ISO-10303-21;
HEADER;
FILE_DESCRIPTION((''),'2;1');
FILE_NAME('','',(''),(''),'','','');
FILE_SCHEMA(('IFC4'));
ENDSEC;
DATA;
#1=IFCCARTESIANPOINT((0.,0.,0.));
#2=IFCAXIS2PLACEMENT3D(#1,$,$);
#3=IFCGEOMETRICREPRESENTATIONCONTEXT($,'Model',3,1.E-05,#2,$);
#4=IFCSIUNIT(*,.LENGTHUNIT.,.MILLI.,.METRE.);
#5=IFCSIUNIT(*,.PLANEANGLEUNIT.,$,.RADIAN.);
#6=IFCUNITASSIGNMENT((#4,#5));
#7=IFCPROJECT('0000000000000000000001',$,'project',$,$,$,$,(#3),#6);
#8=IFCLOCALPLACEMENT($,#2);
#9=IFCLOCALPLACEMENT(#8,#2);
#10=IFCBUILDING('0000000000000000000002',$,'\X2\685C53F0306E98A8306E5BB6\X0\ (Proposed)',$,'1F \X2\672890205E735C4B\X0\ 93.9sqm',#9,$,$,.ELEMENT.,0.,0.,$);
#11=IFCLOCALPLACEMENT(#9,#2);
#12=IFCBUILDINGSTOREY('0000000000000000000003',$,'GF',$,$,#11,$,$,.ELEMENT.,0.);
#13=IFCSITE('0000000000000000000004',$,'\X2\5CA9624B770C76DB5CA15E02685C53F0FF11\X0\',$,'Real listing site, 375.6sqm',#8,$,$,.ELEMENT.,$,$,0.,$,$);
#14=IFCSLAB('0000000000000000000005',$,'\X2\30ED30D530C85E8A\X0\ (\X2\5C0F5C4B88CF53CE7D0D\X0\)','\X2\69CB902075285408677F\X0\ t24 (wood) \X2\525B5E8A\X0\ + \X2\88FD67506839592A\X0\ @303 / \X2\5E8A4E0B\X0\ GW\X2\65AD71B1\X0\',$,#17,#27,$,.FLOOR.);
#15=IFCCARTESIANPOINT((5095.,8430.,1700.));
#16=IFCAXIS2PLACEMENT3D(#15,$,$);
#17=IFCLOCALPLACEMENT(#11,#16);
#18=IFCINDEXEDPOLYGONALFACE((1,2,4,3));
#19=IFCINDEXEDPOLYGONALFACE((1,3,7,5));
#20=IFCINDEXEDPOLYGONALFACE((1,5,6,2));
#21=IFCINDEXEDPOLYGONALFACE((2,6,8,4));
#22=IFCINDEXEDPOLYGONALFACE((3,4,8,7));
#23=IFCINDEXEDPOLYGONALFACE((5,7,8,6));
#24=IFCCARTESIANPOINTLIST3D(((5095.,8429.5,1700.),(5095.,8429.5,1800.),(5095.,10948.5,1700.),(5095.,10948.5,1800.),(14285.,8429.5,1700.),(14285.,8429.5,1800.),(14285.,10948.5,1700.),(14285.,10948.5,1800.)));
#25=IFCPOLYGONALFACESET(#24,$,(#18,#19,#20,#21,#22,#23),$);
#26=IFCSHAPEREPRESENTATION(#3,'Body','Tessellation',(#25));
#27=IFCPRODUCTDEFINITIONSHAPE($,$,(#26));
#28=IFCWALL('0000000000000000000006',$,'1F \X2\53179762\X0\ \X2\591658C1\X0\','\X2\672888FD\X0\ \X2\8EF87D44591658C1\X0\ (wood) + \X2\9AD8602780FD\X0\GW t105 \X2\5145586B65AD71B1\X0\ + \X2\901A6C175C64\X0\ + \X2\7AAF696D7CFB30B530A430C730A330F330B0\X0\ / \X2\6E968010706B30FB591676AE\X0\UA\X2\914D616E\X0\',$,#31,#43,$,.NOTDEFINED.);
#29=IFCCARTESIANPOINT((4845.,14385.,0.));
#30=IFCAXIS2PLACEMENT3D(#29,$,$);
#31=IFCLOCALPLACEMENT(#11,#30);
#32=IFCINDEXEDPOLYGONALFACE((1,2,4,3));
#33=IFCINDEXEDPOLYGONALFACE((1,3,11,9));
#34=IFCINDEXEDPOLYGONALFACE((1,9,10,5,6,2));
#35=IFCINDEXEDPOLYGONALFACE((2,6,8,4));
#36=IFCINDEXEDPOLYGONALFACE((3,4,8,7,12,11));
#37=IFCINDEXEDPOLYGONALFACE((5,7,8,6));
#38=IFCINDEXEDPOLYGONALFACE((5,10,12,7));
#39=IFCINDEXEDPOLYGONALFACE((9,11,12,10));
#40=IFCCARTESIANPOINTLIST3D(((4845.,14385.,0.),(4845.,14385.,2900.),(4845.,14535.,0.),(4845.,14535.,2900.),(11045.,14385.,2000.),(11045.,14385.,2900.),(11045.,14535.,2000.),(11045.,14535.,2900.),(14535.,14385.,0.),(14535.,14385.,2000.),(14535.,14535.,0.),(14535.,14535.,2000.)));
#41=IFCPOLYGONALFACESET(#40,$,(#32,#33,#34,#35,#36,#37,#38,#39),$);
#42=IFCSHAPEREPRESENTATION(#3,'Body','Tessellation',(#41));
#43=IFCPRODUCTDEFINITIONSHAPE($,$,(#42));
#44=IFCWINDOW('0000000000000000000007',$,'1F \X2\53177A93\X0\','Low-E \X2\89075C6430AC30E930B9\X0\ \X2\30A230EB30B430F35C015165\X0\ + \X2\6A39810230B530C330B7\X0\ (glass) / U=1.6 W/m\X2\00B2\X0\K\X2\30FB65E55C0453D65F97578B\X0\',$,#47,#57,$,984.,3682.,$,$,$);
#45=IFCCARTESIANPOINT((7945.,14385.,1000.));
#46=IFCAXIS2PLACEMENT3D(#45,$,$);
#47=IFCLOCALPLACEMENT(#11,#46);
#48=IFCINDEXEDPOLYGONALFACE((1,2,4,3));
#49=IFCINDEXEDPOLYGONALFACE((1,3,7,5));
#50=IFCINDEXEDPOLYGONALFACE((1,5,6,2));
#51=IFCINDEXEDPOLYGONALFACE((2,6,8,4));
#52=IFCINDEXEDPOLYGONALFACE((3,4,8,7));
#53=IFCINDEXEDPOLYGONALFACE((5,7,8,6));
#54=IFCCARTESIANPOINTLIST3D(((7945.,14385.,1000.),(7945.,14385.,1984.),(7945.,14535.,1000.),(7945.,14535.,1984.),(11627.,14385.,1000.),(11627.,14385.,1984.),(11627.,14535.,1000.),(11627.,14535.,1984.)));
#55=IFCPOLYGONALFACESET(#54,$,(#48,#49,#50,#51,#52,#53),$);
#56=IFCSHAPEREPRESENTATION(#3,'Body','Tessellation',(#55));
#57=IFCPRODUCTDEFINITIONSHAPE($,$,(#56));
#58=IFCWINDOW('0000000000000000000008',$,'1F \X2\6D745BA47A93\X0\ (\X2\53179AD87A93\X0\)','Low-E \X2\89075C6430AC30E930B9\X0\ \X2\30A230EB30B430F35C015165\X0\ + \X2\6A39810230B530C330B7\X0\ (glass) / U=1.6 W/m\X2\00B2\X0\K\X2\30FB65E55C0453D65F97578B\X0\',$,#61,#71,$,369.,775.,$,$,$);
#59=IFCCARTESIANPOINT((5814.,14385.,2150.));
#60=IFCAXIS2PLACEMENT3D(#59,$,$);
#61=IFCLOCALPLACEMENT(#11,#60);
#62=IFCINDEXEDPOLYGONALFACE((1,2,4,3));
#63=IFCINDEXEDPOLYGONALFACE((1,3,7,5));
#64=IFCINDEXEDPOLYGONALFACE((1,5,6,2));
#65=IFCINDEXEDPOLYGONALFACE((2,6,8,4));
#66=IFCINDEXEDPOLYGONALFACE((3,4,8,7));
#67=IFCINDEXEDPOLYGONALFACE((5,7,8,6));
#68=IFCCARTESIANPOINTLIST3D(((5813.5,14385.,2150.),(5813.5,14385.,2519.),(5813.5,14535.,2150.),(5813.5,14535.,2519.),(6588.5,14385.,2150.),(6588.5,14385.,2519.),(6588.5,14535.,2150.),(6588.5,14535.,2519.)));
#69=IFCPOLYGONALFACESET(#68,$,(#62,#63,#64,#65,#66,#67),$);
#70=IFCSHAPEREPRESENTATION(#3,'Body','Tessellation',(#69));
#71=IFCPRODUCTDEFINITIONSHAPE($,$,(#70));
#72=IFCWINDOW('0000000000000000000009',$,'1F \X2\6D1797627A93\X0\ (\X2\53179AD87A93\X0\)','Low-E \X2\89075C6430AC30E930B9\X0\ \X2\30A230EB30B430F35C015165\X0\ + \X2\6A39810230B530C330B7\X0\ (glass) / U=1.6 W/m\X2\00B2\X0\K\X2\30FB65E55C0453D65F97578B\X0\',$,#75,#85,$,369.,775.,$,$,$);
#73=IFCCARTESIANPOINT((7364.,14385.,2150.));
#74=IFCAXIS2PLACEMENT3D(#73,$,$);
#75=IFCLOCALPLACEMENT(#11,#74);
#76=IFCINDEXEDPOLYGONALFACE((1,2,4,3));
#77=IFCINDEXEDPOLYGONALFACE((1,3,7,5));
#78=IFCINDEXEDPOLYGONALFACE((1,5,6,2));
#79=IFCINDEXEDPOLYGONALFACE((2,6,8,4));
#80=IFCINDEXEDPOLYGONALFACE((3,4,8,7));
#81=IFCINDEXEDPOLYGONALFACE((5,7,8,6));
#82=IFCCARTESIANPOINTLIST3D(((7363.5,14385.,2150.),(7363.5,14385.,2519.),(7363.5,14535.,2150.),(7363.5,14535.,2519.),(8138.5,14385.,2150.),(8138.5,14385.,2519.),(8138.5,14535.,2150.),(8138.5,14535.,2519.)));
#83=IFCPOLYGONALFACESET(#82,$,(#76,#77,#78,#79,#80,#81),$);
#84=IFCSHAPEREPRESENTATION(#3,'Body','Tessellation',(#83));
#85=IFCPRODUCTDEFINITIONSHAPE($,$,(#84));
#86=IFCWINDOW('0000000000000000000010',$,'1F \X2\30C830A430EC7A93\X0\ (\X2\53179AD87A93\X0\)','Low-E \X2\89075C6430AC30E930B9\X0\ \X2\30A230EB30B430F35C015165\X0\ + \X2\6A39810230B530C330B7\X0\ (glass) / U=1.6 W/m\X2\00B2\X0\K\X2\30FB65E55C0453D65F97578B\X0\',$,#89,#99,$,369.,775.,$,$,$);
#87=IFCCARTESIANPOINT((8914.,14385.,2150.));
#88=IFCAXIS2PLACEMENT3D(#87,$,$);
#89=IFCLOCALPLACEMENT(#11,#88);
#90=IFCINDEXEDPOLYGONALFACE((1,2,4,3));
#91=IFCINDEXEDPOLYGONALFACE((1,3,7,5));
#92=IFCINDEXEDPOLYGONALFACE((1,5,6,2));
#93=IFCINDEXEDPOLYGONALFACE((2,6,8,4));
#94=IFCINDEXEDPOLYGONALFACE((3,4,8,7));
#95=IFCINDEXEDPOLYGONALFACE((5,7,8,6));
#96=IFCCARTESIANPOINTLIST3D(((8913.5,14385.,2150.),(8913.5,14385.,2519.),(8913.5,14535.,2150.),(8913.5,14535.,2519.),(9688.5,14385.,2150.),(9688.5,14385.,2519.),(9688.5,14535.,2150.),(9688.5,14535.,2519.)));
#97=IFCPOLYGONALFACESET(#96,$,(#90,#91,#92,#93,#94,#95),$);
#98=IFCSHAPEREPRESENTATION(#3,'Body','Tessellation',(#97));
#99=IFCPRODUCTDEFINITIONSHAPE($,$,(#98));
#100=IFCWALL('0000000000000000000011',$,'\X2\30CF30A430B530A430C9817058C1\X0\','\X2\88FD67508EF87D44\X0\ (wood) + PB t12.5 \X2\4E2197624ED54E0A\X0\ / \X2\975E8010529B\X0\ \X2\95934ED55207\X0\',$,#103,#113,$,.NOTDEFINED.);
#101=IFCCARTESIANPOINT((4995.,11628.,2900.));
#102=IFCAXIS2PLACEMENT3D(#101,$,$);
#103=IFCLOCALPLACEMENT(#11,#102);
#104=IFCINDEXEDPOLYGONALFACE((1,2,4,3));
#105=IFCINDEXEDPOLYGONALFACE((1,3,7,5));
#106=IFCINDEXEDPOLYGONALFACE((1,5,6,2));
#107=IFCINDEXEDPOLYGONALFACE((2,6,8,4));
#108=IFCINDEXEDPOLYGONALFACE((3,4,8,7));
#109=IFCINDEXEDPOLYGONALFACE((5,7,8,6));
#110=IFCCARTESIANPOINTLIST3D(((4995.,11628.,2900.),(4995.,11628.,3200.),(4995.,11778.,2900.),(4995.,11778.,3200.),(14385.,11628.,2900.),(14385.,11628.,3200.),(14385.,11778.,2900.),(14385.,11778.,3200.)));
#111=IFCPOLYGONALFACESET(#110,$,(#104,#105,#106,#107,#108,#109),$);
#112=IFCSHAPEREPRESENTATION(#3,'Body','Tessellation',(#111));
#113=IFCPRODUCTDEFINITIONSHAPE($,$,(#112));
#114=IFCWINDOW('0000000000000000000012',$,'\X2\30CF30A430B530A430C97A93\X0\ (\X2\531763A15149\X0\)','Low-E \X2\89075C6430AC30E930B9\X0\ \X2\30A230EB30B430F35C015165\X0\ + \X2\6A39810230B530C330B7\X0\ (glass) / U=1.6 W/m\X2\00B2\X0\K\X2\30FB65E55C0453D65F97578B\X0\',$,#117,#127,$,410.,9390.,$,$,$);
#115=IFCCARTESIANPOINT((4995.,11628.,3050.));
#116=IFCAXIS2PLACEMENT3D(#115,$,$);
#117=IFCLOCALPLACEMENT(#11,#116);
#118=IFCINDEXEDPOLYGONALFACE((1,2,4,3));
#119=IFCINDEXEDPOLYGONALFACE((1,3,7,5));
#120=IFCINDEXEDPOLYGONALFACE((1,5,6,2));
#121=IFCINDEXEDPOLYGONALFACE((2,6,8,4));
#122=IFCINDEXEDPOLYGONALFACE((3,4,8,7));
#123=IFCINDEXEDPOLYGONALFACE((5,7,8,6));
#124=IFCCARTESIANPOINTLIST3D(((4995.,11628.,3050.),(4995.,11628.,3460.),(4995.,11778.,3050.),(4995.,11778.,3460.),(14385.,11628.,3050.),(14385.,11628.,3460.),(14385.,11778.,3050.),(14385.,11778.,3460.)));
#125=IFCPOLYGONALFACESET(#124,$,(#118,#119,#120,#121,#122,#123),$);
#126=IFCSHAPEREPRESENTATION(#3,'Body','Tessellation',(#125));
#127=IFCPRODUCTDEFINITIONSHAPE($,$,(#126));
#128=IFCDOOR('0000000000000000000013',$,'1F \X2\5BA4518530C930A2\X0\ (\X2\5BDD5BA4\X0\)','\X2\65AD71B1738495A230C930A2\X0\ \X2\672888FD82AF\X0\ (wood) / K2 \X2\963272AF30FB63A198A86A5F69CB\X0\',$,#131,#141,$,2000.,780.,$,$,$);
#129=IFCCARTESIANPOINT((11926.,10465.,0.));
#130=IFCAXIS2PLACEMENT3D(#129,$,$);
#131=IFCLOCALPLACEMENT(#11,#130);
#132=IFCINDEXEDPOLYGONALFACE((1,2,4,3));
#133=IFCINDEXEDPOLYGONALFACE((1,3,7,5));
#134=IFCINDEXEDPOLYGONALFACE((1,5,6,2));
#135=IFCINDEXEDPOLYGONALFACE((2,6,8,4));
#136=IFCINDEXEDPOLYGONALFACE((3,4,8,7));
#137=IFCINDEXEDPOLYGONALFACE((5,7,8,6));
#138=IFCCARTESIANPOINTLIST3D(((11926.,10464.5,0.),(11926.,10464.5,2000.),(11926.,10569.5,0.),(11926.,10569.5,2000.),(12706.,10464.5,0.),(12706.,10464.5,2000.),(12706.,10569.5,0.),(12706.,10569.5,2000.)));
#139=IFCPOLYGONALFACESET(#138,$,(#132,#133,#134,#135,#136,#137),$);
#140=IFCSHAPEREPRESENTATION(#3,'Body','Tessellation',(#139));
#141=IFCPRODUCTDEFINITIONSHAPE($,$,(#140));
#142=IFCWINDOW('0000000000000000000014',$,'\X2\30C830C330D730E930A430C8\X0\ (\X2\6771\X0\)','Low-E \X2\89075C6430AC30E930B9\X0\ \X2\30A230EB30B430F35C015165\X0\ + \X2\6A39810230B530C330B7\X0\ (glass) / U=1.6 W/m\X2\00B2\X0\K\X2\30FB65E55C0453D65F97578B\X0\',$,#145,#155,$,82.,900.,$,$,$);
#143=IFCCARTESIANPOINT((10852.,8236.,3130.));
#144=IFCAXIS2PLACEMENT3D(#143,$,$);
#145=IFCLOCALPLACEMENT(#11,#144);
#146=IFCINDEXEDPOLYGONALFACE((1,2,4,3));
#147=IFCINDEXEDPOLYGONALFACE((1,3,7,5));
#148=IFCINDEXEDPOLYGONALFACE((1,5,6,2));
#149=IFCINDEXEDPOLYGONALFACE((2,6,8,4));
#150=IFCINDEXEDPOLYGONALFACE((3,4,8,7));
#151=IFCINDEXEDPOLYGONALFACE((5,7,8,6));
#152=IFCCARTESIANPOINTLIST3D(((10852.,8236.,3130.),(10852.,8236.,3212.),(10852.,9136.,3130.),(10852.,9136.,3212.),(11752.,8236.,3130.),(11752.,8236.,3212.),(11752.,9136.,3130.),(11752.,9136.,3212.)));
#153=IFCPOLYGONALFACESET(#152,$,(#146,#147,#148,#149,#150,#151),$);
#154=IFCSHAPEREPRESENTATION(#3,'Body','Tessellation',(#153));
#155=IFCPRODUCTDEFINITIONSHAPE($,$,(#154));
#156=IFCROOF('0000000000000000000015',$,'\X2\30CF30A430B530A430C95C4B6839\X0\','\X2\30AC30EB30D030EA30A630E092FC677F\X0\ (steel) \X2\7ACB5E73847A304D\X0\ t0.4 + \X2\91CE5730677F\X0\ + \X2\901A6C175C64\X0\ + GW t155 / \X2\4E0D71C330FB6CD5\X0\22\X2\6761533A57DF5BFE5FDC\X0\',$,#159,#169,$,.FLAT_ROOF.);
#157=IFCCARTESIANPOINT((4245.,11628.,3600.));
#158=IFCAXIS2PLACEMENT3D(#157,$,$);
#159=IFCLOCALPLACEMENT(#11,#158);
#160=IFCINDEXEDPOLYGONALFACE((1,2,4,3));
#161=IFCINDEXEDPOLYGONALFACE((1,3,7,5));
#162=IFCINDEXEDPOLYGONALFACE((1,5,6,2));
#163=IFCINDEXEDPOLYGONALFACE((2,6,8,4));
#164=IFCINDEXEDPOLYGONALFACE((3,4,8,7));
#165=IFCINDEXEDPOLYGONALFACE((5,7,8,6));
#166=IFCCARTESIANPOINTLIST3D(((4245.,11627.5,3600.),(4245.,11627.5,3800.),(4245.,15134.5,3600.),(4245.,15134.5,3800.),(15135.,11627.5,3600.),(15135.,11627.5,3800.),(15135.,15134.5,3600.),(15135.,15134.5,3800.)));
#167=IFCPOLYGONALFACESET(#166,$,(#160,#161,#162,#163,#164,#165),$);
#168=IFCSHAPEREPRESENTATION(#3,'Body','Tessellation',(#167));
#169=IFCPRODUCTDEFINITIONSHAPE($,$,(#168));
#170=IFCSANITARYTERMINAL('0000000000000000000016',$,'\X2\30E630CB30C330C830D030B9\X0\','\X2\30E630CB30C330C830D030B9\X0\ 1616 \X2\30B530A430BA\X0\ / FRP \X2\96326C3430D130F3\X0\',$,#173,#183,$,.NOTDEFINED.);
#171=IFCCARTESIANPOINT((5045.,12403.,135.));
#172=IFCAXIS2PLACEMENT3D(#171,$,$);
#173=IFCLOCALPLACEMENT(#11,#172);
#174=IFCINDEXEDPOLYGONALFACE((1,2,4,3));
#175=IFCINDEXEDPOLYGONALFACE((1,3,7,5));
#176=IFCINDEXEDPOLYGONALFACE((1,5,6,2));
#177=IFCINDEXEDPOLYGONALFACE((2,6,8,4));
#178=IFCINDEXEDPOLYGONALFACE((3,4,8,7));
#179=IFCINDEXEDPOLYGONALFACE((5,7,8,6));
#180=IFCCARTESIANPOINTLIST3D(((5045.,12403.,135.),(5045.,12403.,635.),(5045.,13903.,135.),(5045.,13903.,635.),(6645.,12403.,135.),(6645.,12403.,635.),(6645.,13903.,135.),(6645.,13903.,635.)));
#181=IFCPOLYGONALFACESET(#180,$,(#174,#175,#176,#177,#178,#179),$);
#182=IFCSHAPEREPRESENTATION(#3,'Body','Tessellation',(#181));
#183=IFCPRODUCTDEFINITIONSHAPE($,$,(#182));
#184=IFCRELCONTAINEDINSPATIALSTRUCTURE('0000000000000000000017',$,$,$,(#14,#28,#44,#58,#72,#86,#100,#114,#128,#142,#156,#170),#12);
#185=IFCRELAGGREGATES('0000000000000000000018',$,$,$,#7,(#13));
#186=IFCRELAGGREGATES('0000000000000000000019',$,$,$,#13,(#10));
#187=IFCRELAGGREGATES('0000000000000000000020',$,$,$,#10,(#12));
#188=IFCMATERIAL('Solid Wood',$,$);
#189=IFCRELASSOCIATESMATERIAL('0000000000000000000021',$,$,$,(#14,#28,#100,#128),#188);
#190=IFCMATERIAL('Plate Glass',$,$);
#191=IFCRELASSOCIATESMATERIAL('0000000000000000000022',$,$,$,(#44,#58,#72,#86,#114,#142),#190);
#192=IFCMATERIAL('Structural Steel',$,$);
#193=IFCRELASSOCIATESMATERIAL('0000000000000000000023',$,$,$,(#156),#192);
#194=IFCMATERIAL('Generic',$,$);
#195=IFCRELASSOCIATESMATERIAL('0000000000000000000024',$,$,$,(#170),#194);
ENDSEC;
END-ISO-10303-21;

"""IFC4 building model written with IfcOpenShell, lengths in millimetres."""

from ifc_helpers import new_model, si_unit, frame, frame_2d, origin, place, context, project, spatial, rectangle, extrude, material, element, fill, save


model = new_model("IFC4")

# Units and contexts
model_context = context("Model", 3, precision=1e-05, world=origin())
ifc_project = project(units=[si_unit("LENGTHUNIT", "METRE", prefix="MILLI"), si_unit("PLANEANGLEUNIT", "RADIAN")], contexts=[model_context])

# Site, building, storey
site_placement = place(None, origin())
site = spatial("IfcSite", under=ifc_project, at=site_placement, Name="岩手県盛岡市桜台１", ObjectType="Real listing site, 375.6sqm", CompositionType="ELEMENT", RefElevation=0.0)
building_placement = place(site_placement, origin())
building = spatial("IfcBuilding", under=site, at=building_placement, Name="桜台の風の家 (Proposed)", ObjectType="1F 木造平屋 93.9sqm", CompositionType="ELEMENT", ElevationOfRefHeight=0.0, ElevationOfTerrain=0.0)
storey_placement = place(building_placement, origin())
storey = spatial("IfcBuildingStorey", under=building, at=storey_placement, Name="GF", CompositionType="ELEMENT", Elevation=0.0)

# Slab
ifc_material_1 = material(Name="Solid Wood")
slab_placement = place(storey_placement, frame((5095.0, 8430.0, 1700.0)))
element("IfcSlab", 1, at=slab_placement, inside=storey, material=ifc_material_1, Name="ロフト床 (小屋裏収納)", Description="構造用合板 t24 (wood) 剛床 + 製材根太 @303 / 床下 GW断熱", PredefinedType="FLOOR", context=model_context, shape_type="SweptSolid", body=[
    extrude(rectangle(XDim=9190.0, YDim=2519.0, at=frame_2d((4595.0, 1259.0))), frame((5095.0, 8430.0, 1700.0)), (0.0, 0.0, 1.0), 100.0),
])

# Wall, openings, windows
wall_1_placement = place(storey_placement, frame((4845.0, 14385.0, 0.0)))
wall_1 = element("IfcWall", 2, at=wall_1_placement, inside=storey, material=ifc_material_1, Name="1F 北面 外壁", Description="木製 軸組外壁 (wood) + 高性能GW t105 充填断熱 + 通気層 + 窯業系サイディング / 準耐火・外皮UA配慮", PredefinedType="NOTDEFINED", context=model_context, shape_type="SweptSolid", body=[
    extrude(rectangle(XDim=9690.0, YDim=150.0, at=frame_2d((4845.0, 75.0))), frame((4845.0, 14385.0, 0.0)), (0.0, 0.0, 1.0), 2900.0),
])
opening_1_placement = place(storey_placement, frame((7945.0, 14385.0, 1000.0)))
opening_1 = element("IfcOpeningElement", 3, at=opening_1_placement, cuts=wall_1, PredefinedType="NOTDEFINED", context=model_context, shape_type="SweptSolid", body=[
    extrude(rectangle(XDim=3682.0, YDim=150.0, at=frame_2d((1841.0, 75.0))), frame((7945.0, 14385.0, 1000.0)), (0.0, 0.0, 1.0), 984.0),
])
opening_2_placement = place(storey_placement, frame((5814.0, 14385.0, 2150.0)))
opening_2 = element("IfcOpeningElement", 4, at=opening_2_placement, cuts=wall_1, PredefinedType="NOTDEFINED", context=model_context, shape_type="SweptSolid", body=[
    extrude(rectangle(XDim=775.0, YDim=150.0, at=frame_2d((387.0, 75.0))), frame((5814.0, 14385.0, 2150.0)), (0.0, 0.0, 1.0), 369.0),
])
opening_3_placement = place(storey_placement, frame((7364.0, 14385.0, 2150.0)))
opening_3 = element("IfcOpeningElement", 5, at=opening_3_placement, cuts=wall_1, PredefinedType="NOTDEFINED", context=model_context, shape_type="SweptSolid", body=[
    extrude(rectangle(XDim=775.0, YDim=150.0, at=frame_2d((387.0, 75.0))), frame((7364.0, 14385.0, 2150.0)), (0.0, 0.0, 1.0), 369.0),
])
opening_4_placement = place(storey_placement, frame((8914.0, 14385.0, 2150.0)))
opening_4 = element("IfcOpeningElement", 6, at=opening_4_placement, cuts=wall_1, PredefinedType="NOTDEFINED", context=model_context, shape_type="SweptSolid", body=[
    extrude(rectangle(XDim=775.0, YDim=150.0, at=frame_2d((387.0, 75.0))), frame((8914.0, 14385.0, 2150.0)), (0.0, 0.0, 1.0), 369.0),
])
ifc_material_2 = material(Name="Plate Glass")
window_1_placement = place(storey_placement, frame((7945.0, 14385.0, 1000.0)))
window_1 = element("IfcWindow", 7, at=window_1_placement, inside=storey, material=ifc_material_2, Name="1F 北窓", Description="Low-E 複層ガラス アルゴン封入 + 樹脂サッシ (glass) / U=1.6 W/m²K・日射取得型", OverallHeight=984.0, OverallWidth=3682.0, context=model_context, shape_type="SweptSolid", body=[
    extrude(rectangle(XDim=3682.0, YDim=150.0, at=frame_2d((1841.0, 75.0))), frame((7945.0, 14385.0, 1000.0)), (0.0, 0.0, 1.0), 984.0),
])
fill(opening_1, window_1)
window_2_placement = place(storey_placement, frame((5814.0, 14385.0, 2150.0)))
window_2 = element("IfcWindow", 8, at=window_2_placement, inside=storey, material=ifc_material_2, Name="1F 浴室窓 (北高窓)", Description="Low-E 複層ガラス アルゴン封入 + 樹脂サッシ (glass) / U=1.6 W/m²K・日射取得型", OverallHeight=369.0, OverallWidth=775.0, context=model_context, shape_type="SweptSolid", body=[
    extrude(rectangle(XDim=775.0, YDim=150.0, at=frame_2d((387.0, 75.0))), frame((5814.0, 14385.0, 2150.0)), (0.0, 0.0, 1.0), 369.0),
])
fill(opening_2, window_2)
window_3_placement = place(storey_placement, frame((7364.0, 14385.0, 2150.0)))
window_3 = element("IfcWindow", 9, at=window_3_placement, inside=storey, material=ifc_material_2, Name="1F 洗面窓 (北高窓)", Description="Low-E 複層ガラス アルゴン封入 + 樹脂サッシ (glass) / U=1.6 W/m²K・日射取得型", OverallHeight=369.0, OverallWidth=775.0, context=model_context, shape_type="SweptSolid", body=[
    extrude(rectangle(XDim=775.0, YDim=150.0, at=frame_2d((387.0, 75.0))), frame((7364.0, 14385.0, 2150.0)), (0.0, 0.0, 1.0), 369.0),
])
fill(opening_3, window_3)
window_4_placement = place(storey_placement, frame((8914.0, 14385.0, 2150.0)))
window_4 = element("IfcWindow", 10, at=window_4_placement, inside=storey, material=ifc_material_2, Name="1F トイレ窓 (北高窓)", Description="Low-E 複層ガラス アルゴン封入 + 樹脂サッシ (glass) / U=1.6 W/m²K・日射取得型", OverallHeight=369.0, OverallWidth=775.0, context=model_context, shape_type="SweptSolid", body=[
    extrude(rectangle(XDim=775.0, YDim=150.0, at=frame_2d((387.0, 75.0))), frame((8914.0, 14385.0, 2150.0)), (0.0, 0.0, 1.0), 369.0),
])
fill(opening_4, window_4)

# Wall, opening, window
wall_2_placement = place(storey_placement, frame((4995.0, 11628.0, 2900.0)))
wall_2 = element("IfcWall", 11, at=wall_2_placement, inside=storey, material=ifc_material_1, Name="ハイサイド腰壁", Description="製材軸組 (wood) + PB t12.5 両面仕上 / 非耐力 間仕切", PredefinedType="NOTDEFINED", context=model_context, shape_type="SweptSolid", body=[
    extrude(rectangle(XDim=9390.0, YDim=150.0, at=frame_2d((4695.0, 75.0))), frame((4995.0, 11628.0, 2900.0)), (0.0, 0.0, 1.0), 700.0),
])
opening_5_placement = place(storey_placement, frame((4995.0, 11628.0, 3050.0)))
opening_5 = element("IfcOpeningElement", 12, at=opening_5_placement, cuts=wall_2, PredefinedType="NOTDEFINED", context=model_context, shape_type="SweptSolid", body=[
    extrude(rectangle(XDim=9390.0, YDim=150.0, at=frame_2d((4695.0, 75.0))), frame((4995.0, 11628.0, 3050.0)), (0.0, 0.0, 1.0), 410.0),
])
window_5_placement = place(storey_placement, frame((4995.0, 11628.0, 3050.0)))
window_5 = element("IfcWindow", 13, at=window_5_placement, inside=storey, material=ifc_material_2, Name="ハイサイド窓 (北採光)", Description="Low-E 複層ガラス アルゴン封入 + 樹脂サッシ (glass) / U=1.6 W/m²K・日射取得型", OverallHeight=410.0, OverallWidth=9390.0, context=model_context, shape_type="SweptSolid", body=[
    extrude(rectangle(XDim=9390.0, YDim=150.0, at=frame_2d((4695.0, 75.0))), frame((4995.0, 11628.0, 3050.0)), (0.0, 0.0, 1.0), 410.0),
])
fill(opening_5, window_5)

# Door
door_1_placement = place(storey_placement, frame((11926.0, 10465.0, 0.0)))
element("IfcDoor", 14, at=door_1_placement, inside=storey, material=ifc_material_1, Name="1F 室内ドア (寝室)", Description="断熱玄関ドア 木製芯 (wood) / K2 防犯・採風機構", OverallHeight=2000.0, OverallWidth=780.0, context=model_context, shape_type="SweptSolid", body=[
    extrude(rectangle(XDim=780.0, YDim=105.0, at=frame_2d((390.0, 52.0))), frame((11926.0, 10465.0, 0.0)), (0.0, 0.0, 1.0), 2000.0),
])

# Window
window_6_placement = place(storey_placement, frame((10852.0, 8236.0, 3130.0)))
element("IfcWindow", 15, at=window_6_placement, inside=storey, material=ifc_material_2, Name="トップライト (東)", Description="Low-E 複層ガラス アルゴン封入 + 樹脂サッシ (glass) / U=1.6 W/m²K・日射取得型", OverallHeight=82.0, OverallWidth=900.0, context=model_context, shape_type="SweptSolid", body=[
    extrude(rectangle(XDim=900.0, YDim=900.0, at=frame_2d((450.0, 450.0))), frame((10852.0, 8236.0, 3130.0)), (0.0, 0.0, 1.0), 82.0),
])

# Roof
ifc_material_3 = material(Name="Structural Steel")
roof_placement = place(storey_placement, frame((4245.0, 11628.0, 3600.0)))
element("IfcRoof", 16, at=roof_placement, inside=storey, material=ifc_material_3, Name="ハイサイド屋根", Description="ガルバリウム鋼板 (steel) 立平葺き t0.4 + 野地板 + 通気層 + GW t155 / 不燃・法22条区域対応", PredefinedType="FLAT_ROOF", context=model_context, shape_type="SweptSolid", body=[
    extrude(rectangle(XDim=10890.0, YDim=3507.0, at=frame_2d((5445.0, 1753.0))), frame((4245.0, 11628.0, 3600.0)), (0.0, 0.0, 1.0), 200.0),
])

# Sanitary terminal
ifc_material_4 = material(Name="Generic")
sanitary_terminal_1_placement = place(storey_placement, frame((5045.0, 12403.0, 135.0)))
element("IfcSanitaryTerminal", 17, at=sanitary_terminal_1_placement, inside=storey, material=ifc_material_4, Name="ユニットバス", Description="ユニットバス 1616 サイズ / FRP 防水パン", PredefinedType="NOTDEFINED", context=model_context, shape_type="SweptSolid", body=[
    extrude(rectangle(XDim=1600.0, YDim=1500.0, at=frame_2d((800.0, 750.0))), frame((5045.0, 12403.0, 135.0)), (0.0, 0.0, 1.0), 500.0),
])

save(model, "model.ifc")
